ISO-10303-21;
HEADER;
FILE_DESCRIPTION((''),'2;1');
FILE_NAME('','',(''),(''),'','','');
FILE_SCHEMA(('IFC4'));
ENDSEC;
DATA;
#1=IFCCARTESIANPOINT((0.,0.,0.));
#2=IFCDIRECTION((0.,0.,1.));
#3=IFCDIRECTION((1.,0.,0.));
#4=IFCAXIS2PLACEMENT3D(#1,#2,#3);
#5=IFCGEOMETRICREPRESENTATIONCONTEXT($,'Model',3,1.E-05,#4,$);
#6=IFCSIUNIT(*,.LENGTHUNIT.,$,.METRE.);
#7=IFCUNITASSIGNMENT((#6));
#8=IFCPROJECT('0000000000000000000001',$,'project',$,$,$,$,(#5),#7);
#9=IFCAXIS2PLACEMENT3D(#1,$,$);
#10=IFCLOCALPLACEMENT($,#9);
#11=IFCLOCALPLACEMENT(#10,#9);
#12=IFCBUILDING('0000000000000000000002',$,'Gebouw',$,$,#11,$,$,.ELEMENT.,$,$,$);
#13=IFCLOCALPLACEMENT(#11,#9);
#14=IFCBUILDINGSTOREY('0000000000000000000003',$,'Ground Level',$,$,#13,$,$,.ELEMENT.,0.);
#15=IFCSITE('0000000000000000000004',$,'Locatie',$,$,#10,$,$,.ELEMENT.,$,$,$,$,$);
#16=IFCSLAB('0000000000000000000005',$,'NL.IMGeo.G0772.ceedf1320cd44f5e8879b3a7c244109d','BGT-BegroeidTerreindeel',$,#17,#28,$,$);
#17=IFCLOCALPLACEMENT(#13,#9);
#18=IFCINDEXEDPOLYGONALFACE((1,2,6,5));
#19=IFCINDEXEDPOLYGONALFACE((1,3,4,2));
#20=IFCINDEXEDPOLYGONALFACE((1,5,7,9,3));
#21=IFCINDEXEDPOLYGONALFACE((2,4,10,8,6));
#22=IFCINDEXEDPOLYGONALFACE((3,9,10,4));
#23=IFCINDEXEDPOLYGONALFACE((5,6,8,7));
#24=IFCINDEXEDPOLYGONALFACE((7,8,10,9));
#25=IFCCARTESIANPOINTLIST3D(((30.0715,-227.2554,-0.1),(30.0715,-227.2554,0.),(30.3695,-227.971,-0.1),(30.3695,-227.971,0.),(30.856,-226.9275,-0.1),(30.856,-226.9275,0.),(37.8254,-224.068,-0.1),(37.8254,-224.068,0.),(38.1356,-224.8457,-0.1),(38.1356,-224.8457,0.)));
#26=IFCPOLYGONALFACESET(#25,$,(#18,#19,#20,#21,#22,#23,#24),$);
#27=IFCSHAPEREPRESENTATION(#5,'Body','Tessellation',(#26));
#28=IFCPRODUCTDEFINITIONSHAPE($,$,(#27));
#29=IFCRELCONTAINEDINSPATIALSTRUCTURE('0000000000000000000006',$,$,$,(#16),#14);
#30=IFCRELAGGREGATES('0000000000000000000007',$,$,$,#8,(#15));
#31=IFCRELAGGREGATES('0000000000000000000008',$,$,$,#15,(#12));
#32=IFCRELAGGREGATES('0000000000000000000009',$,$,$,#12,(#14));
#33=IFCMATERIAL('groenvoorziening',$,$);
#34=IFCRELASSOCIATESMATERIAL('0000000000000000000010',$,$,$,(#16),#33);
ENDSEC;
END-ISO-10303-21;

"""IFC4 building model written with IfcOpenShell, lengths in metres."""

from ifc_helpers import new_model, si_unit, frame, origin, origin_with_axes, place, context, project, spatial, polyline, outline, extrude, material, element, save


model = new_model("IFC4")

# Units and contexts
model_context = context("Model", 3, precision=1e-05, world=origin_with_axes())
ifc_project = project(units=[si_unit("LENGTHUNIT", "METRE")], contexts=[model_context])

# Site, building, storey
site_placement = place(None, origin())
site = spatial("IfcSite", under=ifc_project, at=site_placement, Name="Locatie", CompositionType="ELEMENT")
building_placement = place(site_placement, origin())
building = spatial("IfcBuilding", under=site, at=building_placement, Name="Gebouw", CompositionType="ELEMENT")
storey_placement = place(building_placement, origin())
storey = spatial("IfcBuildingStorey", under=building, at=storey_placement, Name="Ground Level", CompositionType="ELEMENT", Elevation=0.0)

# Slab
ifc_material_1 = material(Name="groenvoorziening")
slab_1_placement = place(storey_placement, origin())
element("IfcSlab", 1, at=slab_1_placement, inside=storey, material=ifc_material_1, Name="NL.IMGeo.G0772.ceedf1320cd44f5e8879b3a7c244109d", Description="BGT-BegroeidTerreindeel", context=model_context, shape_type="SweptSolid", body=[
    extrude(outline(polyline([(37.8254, -224.068), (38.1356, -224.8457), (30.3695, -227.971), (30.0715, -227.2554), (30.856, -226.9275), (37.8254, -224.068)])), frame((0.0, 0.0, -0.1), z_axis=(0.0, 0.0, 1.0), x_axis=(1.0, 0.0, 0.0)), (0.0, 0.0, 1.0), 0.1),
])

save(model, "model.ifc")
